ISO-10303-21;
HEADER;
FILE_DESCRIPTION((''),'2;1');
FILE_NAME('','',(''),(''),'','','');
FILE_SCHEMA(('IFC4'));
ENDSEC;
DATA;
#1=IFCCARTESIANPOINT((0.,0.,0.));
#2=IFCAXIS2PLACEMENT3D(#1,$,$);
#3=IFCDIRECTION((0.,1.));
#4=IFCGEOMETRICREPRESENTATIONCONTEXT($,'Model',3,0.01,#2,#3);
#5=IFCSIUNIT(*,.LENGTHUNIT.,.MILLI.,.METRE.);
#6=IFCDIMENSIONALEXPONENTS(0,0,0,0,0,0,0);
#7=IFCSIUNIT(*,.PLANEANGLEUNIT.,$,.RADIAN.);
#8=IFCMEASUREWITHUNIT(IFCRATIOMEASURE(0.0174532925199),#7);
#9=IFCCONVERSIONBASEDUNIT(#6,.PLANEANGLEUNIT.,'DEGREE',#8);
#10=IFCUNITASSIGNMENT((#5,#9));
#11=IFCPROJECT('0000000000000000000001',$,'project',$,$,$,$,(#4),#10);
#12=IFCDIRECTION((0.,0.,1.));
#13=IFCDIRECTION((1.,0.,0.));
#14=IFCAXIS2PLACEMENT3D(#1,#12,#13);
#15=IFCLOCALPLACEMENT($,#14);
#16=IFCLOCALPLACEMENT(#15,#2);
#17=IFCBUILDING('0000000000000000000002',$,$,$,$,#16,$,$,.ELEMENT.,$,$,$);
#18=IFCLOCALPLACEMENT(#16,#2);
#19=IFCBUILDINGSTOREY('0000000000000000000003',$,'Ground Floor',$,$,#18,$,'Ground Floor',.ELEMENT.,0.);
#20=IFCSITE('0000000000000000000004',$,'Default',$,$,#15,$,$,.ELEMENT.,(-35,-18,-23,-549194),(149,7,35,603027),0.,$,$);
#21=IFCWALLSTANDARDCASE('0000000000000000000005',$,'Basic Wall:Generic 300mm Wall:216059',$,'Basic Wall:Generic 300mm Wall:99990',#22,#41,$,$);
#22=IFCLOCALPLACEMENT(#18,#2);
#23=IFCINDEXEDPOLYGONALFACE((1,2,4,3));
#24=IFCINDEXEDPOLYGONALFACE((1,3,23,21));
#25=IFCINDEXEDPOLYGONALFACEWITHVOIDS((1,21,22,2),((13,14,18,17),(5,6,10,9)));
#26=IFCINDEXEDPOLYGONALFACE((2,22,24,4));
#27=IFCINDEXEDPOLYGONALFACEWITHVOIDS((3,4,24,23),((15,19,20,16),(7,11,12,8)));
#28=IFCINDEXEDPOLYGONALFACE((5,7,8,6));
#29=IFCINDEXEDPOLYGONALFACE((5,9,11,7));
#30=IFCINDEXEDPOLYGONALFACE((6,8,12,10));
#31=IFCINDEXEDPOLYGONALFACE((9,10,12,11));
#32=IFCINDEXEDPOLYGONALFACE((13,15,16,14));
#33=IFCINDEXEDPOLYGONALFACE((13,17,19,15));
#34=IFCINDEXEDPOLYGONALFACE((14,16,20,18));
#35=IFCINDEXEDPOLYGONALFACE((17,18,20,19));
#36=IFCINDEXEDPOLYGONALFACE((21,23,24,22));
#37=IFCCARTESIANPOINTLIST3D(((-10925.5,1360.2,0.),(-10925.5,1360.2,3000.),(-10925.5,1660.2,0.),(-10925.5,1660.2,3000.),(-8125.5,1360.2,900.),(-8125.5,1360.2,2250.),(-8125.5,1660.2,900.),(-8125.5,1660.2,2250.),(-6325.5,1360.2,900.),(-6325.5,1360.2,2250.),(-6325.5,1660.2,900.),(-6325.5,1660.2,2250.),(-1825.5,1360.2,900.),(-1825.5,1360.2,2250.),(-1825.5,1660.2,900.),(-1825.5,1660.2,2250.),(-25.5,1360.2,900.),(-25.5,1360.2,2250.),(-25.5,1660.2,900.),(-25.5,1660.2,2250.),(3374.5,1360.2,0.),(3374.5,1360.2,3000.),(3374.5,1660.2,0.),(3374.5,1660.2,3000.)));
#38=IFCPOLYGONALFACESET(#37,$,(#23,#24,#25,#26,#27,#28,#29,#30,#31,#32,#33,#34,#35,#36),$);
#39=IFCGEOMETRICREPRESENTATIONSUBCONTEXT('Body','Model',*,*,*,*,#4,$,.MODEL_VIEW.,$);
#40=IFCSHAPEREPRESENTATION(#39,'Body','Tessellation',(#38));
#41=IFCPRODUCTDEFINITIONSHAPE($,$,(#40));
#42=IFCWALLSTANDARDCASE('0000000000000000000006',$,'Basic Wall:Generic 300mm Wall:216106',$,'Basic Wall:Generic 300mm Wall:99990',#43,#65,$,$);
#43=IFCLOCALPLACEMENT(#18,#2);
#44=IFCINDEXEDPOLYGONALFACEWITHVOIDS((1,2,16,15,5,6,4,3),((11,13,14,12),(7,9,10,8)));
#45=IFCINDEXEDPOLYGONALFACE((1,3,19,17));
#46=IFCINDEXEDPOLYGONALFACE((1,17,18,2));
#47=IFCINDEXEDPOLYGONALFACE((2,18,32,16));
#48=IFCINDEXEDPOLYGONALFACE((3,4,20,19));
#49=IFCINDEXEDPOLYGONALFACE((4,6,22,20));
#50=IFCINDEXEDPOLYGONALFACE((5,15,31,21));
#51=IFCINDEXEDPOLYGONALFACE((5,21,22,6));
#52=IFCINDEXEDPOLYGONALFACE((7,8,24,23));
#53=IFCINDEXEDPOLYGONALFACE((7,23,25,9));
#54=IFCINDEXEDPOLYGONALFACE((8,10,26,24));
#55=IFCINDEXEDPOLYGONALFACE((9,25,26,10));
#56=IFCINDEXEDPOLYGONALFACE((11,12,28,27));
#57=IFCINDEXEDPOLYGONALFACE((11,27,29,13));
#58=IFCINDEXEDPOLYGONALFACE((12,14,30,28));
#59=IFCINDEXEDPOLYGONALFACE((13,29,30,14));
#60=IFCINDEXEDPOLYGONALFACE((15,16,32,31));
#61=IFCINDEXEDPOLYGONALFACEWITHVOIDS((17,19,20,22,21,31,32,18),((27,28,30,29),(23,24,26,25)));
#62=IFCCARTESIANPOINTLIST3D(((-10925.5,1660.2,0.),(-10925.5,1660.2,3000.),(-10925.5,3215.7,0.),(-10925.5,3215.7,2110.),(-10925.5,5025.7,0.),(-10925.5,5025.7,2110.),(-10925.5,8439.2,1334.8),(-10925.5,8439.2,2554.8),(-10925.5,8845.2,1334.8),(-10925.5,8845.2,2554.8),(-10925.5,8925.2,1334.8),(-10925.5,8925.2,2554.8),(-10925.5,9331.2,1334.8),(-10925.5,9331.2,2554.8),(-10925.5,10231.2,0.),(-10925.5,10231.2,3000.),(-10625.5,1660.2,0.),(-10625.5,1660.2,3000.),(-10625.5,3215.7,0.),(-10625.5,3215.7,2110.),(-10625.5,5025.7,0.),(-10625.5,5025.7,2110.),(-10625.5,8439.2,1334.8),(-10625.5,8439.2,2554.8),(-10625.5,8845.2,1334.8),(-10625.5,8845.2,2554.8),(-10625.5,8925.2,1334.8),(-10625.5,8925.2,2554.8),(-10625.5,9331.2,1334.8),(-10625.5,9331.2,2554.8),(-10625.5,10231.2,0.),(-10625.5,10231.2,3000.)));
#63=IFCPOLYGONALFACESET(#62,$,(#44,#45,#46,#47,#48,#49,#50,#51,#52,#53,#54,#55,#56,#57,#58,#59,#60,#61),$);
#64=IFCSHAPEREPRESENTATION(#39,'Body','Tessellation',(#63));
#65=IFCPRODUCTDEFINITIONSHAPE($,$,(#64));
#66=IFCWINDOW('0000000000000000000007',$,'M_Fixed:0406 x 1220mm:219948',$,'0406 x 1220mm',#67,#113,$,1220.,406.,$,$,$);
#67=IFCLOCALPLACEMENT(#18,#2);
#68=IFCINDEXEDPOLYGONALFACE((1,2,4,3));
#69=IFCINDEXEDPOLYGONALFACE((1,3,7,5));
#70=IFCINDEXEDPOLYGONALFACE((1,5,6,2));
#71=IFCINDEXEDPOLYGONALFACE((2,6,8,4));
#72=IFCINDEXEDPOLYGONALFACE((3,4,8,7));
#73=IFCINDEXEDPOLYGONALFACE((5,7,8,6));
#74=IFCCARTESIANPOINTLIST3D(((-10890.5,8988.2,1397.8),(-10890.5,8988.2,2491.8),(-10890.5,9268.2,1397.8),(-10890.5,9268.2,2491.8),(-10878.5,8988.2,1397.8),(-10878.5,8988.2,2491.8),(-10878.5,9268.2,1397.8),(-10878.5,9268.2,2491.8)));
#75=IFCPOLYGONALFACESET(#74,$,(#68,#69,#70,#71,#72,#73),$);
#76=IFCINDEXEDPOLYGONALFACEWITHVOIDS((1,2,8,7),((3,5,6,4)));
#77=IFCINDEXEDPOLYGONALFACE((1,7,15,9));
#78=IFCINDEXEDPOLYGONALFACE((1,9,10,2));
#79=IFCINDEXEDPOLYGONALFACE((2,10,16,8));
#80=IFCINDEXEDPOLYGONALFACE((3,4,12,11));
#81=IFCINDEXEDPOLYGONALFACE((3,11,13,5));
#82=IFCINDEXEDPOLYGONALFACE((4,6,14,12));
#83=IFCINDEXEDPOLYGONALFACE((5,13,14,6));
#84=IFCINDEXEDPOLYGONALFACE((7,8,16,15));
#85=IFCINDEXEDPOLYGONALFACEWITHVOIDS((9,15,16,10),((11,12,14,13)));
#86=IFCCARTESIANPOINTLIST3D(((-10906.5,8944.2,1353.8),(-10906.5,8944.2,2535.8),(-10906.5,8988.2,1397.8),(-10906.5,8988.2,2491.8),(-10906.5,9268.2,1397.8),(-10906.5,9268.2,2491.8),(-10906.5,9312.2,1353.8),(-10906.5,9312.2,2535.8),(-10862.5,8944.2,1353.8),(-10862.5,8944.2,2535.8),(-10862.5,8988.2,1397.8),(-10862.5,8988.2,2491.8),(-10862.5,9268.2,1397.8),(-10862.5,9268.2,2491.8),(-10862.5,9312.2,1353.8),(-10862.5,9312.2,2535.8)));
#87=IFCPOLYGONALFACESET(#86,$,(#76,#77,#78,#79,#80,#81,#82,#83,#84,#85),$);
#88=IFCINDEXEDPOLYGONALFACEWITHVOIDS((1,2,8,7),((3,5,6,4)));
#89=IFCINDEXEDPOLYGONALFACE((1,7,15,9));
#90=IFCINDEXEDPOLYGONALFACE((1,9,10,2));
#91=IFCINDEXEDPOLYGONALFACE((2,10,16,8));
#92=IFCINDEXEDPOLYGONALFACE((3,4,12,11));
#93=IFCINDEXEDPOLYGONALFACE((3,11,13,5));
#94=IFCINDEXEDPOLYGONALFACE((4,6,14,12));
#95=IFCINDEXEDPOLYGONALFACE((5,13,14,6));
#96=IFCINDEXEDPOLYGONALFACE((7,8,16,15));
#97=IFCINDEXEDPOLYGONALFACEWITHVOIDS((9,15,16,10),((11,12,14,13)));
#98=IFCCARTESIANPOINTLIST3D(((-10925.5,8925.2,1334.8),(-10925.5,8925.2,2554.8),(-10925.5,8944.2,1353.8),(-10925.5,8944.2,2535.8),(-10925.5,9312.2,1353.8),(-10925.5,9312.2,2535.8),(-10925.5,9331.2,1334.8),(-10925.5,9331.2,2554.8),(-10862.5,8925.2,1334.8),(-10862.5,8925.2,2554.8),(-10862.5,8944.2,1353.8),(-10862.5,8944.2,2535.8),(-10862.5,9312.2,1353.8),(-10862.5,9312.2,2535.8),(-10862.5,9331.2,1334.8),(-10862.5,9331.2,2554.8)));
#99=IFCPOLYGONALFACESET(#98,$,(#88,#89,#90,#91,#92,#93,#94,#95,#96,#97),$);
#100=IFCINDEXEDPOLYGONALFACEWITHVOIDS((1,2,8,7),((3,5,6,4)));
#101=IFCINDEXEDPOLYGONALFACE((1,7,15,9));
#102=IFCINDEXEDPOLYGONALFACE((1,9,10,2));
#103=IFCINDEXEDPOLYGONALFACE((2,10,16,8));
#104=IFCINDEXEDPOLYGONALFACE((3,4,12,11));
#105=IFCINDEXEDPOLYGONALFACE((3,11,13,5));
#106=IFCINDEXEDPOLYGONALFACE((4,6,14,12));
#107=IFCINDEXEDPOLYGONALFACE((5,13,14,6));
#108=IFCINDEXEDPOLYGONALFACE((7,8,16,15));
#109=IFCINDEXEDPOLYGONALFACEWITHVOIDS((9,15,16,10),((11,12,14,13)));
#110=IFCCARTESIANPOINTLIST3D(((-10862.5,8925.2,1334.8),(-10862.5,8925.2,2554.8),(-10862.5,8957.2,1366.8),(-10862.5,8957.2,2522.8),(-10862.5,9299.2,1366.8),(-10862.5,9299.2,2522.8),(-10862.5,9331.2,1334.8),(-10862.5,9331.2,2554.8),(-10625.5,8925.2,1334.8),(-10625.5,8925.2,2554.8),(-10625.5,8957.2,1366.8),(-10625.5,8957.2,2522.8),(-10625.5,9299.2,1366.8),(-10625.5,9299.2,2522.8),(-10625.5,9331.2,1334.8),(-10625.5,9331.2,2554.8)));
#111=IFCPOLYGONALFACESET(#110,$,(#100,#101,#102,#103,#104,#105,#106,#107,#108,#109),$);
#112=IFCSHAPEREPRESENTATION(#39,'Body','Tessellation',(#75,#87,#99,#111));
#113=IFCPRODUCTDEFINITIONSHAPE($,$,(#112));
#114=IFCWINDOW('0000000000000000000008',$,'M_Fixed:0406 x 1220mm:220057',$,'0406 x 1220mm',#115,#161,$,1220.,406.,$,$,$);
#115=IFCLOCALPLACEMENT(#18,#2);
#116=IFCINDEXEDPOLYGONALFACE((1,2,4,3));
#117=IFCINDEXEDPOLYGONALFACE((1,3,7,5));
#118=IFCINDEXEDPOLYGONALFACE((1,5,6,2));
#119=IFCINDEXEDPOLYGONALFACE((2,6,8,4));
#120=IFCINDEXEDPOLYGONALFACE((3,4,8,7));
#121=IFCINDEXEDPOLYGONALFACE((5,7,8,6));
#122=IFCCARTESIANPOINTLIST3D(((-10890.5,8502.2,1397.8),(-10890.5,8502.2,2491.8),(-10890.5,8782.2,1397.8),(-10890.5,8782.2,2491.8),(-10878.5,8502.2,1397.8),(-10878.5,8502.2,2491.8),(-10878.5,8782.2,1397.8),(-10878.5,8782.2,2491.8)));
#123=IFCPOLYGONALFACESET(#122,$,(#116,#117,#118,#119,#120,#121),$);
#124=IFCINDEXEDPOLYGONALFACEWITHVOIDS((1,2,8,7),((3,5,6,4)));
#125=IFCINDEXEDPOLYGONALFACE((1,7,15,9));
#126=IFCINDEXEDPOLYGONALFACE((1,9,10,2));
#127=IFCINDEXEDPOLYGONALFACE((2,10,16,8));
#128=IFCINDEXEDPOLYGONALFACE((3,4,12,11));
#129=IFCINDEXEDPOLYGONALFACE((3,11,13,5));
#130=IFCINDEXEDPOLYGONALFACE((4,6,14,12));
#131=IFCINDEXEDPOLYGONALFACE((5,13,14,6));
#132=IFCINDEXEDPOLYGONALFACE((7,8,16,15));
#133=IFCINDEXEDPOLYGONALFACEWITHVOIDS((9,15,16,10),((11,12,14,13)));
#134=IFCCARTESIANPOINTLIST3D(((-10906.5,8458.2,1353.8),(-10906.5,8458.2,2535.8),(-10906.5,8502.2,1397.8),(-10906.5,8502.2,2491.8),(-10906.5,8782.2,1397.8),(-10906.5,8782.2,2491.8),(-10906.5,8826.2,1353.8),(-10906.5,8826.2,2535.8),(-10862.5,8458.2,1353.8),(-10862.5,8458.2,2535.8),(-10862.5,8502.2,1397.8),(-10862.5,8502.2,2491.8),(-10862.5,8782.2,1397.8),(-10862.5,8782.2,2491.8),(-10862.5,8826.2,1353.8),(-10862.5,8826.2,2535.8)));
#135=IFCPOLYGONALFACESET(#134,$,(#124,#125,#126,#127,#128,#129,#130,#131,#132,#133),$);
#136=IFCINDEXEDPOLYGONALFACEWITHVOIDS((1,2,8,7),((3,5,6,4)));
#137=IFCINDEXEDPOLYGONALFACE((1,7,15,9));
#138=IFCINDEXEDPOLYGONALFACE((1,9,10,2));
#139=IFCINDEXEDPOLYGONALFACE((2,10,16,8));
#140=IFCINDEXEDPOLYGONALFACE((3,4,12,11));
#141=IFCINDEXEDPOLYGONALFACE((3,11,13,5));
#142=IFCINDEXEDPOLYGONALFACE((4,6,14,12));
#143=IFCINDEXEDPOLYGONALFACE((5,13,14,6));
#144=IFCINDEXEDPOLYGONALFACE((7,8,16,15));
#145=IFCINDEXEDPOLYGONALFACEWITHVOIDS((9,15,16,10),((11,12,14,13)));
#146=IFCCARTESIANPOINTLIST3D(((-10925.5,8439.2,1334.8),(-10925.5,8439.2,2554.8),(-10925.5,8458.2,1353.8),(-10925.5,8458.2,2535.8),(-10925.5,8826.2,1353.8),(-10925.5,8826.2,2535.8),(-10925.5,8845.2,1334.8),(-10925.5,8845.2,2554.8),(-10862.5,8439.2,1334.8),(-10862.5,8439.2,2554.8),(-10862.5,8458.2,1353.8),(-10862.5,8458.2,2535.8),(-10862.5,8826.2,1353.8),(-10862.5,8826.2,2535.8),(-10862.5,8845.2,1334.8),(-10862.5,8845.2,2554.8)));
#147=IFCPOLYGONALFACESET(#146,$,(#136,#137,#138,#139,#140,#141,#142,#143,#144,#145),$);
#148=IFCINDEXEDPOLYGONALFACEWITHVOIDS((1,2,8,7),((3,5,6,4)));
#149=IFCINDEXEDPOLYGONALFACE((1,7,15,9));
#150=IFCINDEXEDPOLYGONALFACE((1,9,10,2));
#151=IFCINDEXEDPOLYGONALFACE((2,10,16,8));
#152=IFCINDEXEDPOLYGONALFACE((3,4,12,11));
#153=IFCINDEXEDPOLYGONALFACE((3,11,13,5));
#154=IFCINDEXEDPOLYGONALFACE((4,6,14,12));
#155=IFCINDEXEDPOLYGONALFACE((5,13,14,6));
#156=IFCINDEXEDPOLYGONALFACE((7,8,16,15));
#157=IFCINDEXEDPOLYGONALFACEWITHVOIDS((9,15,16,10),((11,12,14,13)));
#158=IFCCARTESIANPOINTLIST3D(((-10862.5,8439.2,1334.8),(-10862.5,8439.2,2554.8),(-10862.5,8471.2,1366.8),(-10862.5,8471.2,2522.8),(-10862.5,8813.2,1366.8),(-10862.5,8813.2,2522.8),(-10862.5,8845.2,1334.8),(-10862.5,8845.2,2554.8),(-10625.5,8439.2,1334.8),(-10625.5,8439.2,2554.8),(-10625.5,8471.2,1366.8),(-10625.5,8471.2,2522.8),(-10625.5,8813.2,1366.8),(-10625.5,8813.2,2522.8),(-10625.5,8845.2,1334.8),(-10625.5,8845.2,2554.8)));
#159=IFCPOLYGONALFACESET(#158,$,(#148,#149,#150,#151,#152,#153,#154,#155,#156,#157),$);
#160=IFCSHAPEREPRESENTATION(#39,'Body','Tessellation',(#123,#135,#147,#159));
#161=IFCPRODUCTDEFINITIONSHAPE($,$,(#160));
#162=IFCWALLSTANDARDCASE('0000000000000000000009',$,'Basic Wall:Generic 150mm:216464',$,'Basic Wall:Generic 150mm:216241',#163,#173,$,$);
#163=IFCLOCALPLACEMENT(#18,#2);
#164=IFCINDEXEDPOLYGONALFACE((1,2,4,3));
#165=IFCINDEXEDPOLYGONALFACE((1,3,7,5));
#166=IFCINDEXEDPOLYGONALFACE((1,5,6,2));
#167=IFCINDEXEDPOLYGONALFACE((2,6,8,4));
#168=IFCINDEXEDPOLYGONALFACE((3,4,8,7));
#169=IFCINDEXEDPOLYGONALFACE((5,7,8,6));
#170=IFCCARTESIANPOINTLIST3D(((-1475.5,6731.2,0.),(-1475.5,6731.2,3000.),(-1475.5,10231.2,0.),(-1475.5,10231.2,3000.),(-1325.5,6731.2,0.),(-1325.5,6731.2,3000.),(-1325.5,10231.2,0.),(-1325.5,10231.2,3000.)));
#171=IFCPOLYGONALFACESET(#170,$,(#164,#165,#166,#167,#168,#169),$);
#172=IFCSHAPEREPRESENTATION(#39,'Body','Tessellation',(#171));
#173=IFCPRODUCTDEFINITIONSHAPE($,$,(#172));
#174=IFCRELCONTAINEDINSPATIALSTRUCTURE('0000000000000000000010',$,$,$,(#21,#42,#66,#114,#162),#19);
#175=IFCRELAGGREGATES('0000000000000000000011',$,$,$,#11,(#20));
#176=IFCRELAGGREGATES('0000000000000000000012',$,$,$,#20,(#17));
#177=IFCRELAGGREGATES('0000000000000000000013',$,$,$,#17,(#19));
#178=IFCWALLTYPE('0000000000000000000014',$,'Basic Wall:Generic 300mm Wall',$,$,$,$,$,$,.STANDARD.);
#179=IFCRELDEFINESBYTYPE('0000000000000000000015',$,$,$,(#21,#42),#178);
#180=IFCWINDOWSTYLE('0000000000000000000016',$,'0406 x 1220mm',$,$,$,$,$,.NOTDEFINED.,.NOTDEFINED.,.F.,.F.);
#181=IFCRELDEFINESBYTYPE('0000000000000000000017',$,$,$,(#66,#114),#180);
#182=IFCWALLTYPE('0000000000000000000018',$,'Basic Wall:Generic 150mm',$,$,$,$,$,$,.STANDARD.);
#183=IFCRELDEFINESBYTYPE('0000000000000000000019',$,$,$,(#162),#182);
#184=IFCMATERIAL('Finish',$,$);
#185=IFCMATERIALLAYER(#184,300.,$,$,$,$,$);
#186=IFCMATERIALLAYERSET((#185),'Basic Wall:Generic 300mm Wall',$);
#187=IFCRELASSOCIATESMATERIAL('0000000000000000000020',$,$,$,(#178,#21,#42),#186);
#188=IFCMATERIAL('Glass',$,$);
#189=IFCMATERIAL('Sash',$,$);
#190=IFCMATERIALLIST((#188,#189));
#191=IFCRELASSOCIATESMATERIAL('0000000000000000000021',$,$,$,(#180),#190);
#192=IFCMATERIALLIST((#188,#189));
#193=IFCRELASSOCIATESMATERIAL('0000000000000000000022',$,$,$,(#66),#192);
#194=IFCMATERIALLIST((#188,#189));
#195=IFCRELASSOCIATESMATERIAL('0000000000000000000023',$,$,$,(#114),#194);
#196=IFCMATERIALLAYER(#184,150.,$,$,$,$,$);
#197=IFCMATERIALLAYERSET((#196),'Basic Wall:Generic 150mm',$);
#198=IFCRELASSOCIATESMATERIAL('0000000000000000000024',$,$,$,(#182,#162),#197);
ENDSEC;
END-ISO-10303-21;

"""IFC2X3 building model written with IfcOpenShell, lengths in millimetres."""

from ifc_helpers import new_model, entity, si_unit, converted_unit, direction, frame, frame_2d, origin, origin_with_axes, place, context, subcontext, project, spatial, polyline, rectangle, outline, extrude, source, transform, mapped, material, material_list, layer, layer_set, layer_usage, type_object, type_shapes, element, fill, save


model = new_model("IFC2X3")

# Units and contexts
model_context = context("Model", 3, precision=0.01, world=origin(), true_north=direction((0.0, 1.0)))
body_context = subcontext(model_context, "Body", "Model", "MODEL_VIEW")
ifc_project = project(units=[si_unit("LENGTHUNIT", "METRE", prefix="MILLI"), converted_unit("PLANEANGLEUNIT", "DEGREE", entity("IfcRatioMeasure", 0.0174532925199), si_unit("PLANEANGLEUNIT", "RADIAN"), dimensions=[0, 0, 0, 0, 0, 0, 0])], contexts=[model_context])

# Site, building, storey
site_placement = place(None, origin_with_axes())
site = spatial("IfcSite", under=ifc_project, at=site_placement, Name="Default", CompositionType="ELEMENT", RefLatitude=(-35, -18, -23, -549194), RefLongitude=(149, 7, 35, 603027), RefElevation=0.0)
building_placement = place(site_placement, origin())
building = spatial("IfcBuilding", under=site, at=building_placement, CompositionType="ELEMENT")
storey_placement = place(building_placement, origin())
storey = spatial("IfcBuildingStorey", under=building, at=storey_placement, Name="Ground Floor", LongName="Ground Floor", CompositionType="ELEMENT", Elevation=0.0)

# Shared definitions
ifc_material_1 = material(Name="Finish")
ifc_layer_1 = layer(ifc_material_1, 300.0)
ifc_layer_set_1 = layer_set([ifc_layer_1], Name="Basic Wall:Generic 300mm Wall")
wall_type_1 = type_object("IfcWallType", Name="Basic Wall:Generic 300mm Wall", PredefinedType="STANDARD", material=ifc_layer_set_1)
ifc_material_2 = material(Name="Glass")
ifc_material_3 = material(Name="Sash")

# Wall, openings
ifc_layer_usage_1 = layer_usage(ifc_layer_set_1, "AXIS2", "NEGATIVE", 150.0)
wall_1_placement = place(storey_placement, frame((3374.5, 1510.2, 0.0), z_axis=(0.0, 0.0, 1.0), x_axis=(-1.0, 0.0, 0.0)))
wall_1 = element("IfcWallStandardCase", 1, at=wall_1_placement, inside=storey, type_object=wall_type_1, material=ifc_layer_usage_1, Name="Basic Wall:Generic 300mm Wall:216059", ObjectType="Basic Wall:Generic 300mm Wall:99990", context=body_context, shape_type="SweptSolid", body=[
    extrude(rectangle(XDim=14300.0, YDim=300.0, at=frame_2d((7150.0, 0.0), x_axis=(-1.0, 0.0))), origin(), (0.0, 0.0, 1.0), 3000.0),
])
opening_1_placement = place(wall_1_placement, frame((5200.0, 150.0, 900.0)))
element("IfcOpeningElement", 2, at=opening_1_placement, cuts=wall_1, ObjectType="Opening", context=body_context, shape_type="SweptSolid", body=[
    extrude(rectangle(XDim=1350.0, YDim=1800.0, at=frame_2d((675.0, 900.0), x_axis=(-1.0, 0.0))), frame((0.0, 0.0, 0.0), z_axis=(0.0, -1.0, 0.0), x_axis=(0.0, 0.0, 1.0)), (0.0, 0.0, 1.0), 300.0),
])
opening_2_placement = place(wall_1_placement, frame((11500.0, 150.0, 900.0)))
element("IfcOpeningElement", 3, at=opening_2_placement, cuts=wall_1, ObjectType="Opening", context=body_context, shape_type="SweptSolid", body=[
    extrude(rectangle(XDim=1350.0, YDim=1800.0, at=frame_2d((675.0, 900.0), x_axis=(-1.0, 0.0))), frame((0.0, 0.0, 0.0), z_axis=(0.0, -1.0, 0.0), x_axis=(0.0, 0.0, 1.0)), (0.0, 0.0, 1.0), 300.0),
])

# Wall, openings, windows
ifc_layer_usage_2 = layer_usage(ifc_layer_set_1, "AXIS2", "NEGATIVE", 150.0)
wall_2_placement = place(storey_placement, frame((-10775.5, 1660.2, 0.0), z_axis=(0.0, 0.0, 1.0), x_axis=(0.0, 1.0, 0.0)))
wall_2 = element("IfcWallStandardCase", 4, at=wall_2_placement, inside=storey, type_object=wall_type_1, material=ifc_layer_usage_2, Name="Basic Wall:Generic 300mm Wall:216106", ObjectType="Basic Wall:Generic 300mm Wall:99990", context=body_context, shape_type="SweptSolid", body=[
    extrude(rectangle(XDim=8571.0, YDim=300.0, at=frame_2d((4285.5, 0.0), x_axis=(-1.0, 0.0))), origin(), (0.0, 0.0, 1.0), 3000.0),
])
opening_3_placement = place(wall_2_placement, frame((1555.5, -150.0, 0.0)))
element("IfcOpeningElement", 5, at=opening_3_placement, cuts=wall_2, ObjectType="Opening", context=body_context, shape_type="SweptSolid", body=[
    extrude(rectangle(XDim=2110.0, YDim=1810.0, at=frame_2d((1055.0, 905.0), x_axis=(1.0, 0.0))), frame((0.0, 0.0, 0.0), z_axis=(0.0, 1.0, 0.0), x_axis=(0.0, 0.0, 1.0)), (0.0, 0.0, 1.0), 300.0),
])
opening_4_placement = place(wall_2_placement, frame((7265.0, -150.0, 1334.8)))
opening_4 = element("IfcOpeningElement", 6, at=opening_4_placement, cuts=wall_2, ObjectType="Opening", context=body_context, shape_type="SweptSolid", body=[
    extrude(rectangle(XDim=1220.0, YDim=406.0, at=frame_2d((610.0, 203.0), x_axis=(1.0, 0.0))), frame((0.0, 0.0, 0.0), z_axis=(0.0, 1.0, 0.0), x_axis=(0.0, 0.0, 1.0)), (0.0, 0.0, 1.0), 300.0),
])
opening_5_placement = place(wall_2_placement, frame((6779.0, -150.0, 1334.8)))
opening_5 = element("IfcOpeningElement", 7, at=opening_5_placement, cuts=wall_2, ObjectType="Opening", context=body_context, shape_type="SweptSolid", body=[
    extrude(rectangle(XDim=1220.0, YDim=406.0, at=frame_2d((610.0, 203.0), x_axis=(1.0, 0.0))), frame((0.0, 0.0, 0.0), z_axis=(0.0, 1.0, 0.0), x_axis=(0.0, 0.0, 1.0)), (0.0, 0.0, 1.0), 300.0),
])
ifc_material_list_1 = material_list([ifc_material_2, ifc_material_3])
ifc_material_list_2 = material_list([ifc_material_2, ifc_material_3])
window_style_1 = type_object("IfcWindowStyle", Name="0406 x 1220mm", ConstructionType="NOTDEFINED", OperationType="NOTDEFINED", ParameterTakesPrecedence=False, Sizeable=False, material=ifc_material_list_2)
shared_shape_1 = source(origin(), body_context, "Body", "SweptSolid", [
    extrude(rectangle(XDim=12.0, YDim=280.0, at=frame_2d((0.0, 0.0), x_axis=(1.0, 0.0))), frame((203.0, 259.0, 63.0), z_axis=(0.0, 0.0, 1.0), x_axis=(0.0, -1.0, 0.0)), (0.0, 0.0, 1.0), 1094.0),
    extrude(outline(polyline([(-184.0, -591.0), (184.0, -591.0), (184.0, 591.0), (-184.0, 591.0), (-184.0, -591.0)]), holes=[polyline([(-140.0, -547.0), (-140.0, 547.0), (140.0, 547.0), (140.0, -547.0), (-140.0, -547.0)])]), frame((203.0, 237.0, 610.0), z_axis=(0.0, 1.0, 0.0), x_axis=(1.0, 0.0, 0.0)), (0.0, 0.0, 1.0), 44.0),
    extrude(outline(polyline([(-203.0, -610.0), (203.0, -610.0), (203.0, 610.0), (-203.0, 610.0), (-203.0, -610.0)]), holes=[polyline([(-184.0, -591.0), (-184.0, 591.0), (184.0, 591.0), (184.0, -591.0), (-184.0, -591.0)])]), frame((203.0, 237.0, 610.0), z_axis=(0.0, 1.0, 0.0), x_axis=(1.0, 0.0, 0.0)), (0.0, 0.0, 1.0), 63.0),
    extrude(outline(polyline([(-203.0, -610.0), (203.0, -610.0), (203.0, 610.0), (-203.0, 610.0), (-203.0, -610.0)]), holes=[polyline([(-171.0, -578.0), (-171.0, 578.0), (171.0, 578.0), (171.0, -578.0), (-171.0, -578.0)])]), frame((203.0, 0.0, 610.0), z_axis=(0.0, 1.0, 0.0), x_axis=(1.0, 0.0, 0.0)), (0.0, 0.0, 1.0), 237.0),
])
type_shapes(window_style_1, [shared_shape_1])
window_1_placement = place(opening_4_placement, origin())
window_1 = element("IfcWindow", 8, at=window_1_placement, inside=storey, type_object=window_style_1, material=ifc_material_list_1, Name="M_Fixed:0406 x 1220mm:219948", ObjectType="0406 x 1220mm", OverallHeight=1220.0, OverallWidth=406.0, context=body_context, shape_type="MappedRepresentation", body=[
    mapped(shared_shape_1, transform((0.0, 0.0, 0.0), scale=1.0)),
])
fill(opening_4, window_1)
ifc_material_list_3 = material_list([ifc_material_2, ifc_material_3])
window_2_placement = place(opening_5_placement, origin())
window_2 = element("IfcWindow", 9, at=window_2_placement, inside=storey, type_object=window_style_1, material=ifc_material_list_3, Name="M_Fixed:0406 x 1220mm:220057", ObjectType="0406 x 1220mm", OverallHeight=1220.0, OverallWidth=406.0, context=body_context, shape_type="MappedRepresentation", body=[
    mapped(shared_shape_1, transform((0.0, 0.0, 0.0), scale=1.0)),
])
fill(opening_5, window_2)

# Wall
ifc_layer_2 = layer(ifc_material_1, 150.0)
ifc_layer_set_2 = layer_set([ifc_layer_2], Name="Basic Wall:Generic 150mm")
ifc_layer_usage_3 = layer_usage(ifc_layer_set_2, "AXIS2", "NEGATIVE", 75.0)
wall_type_2 = type_object("IfcWallType", Name="Basic Wall:Generic 150mm", PredefinedType="STANDARD", material=ifc_layer_set_2)
wall_3_placement = place(storey_placement, frame((-1400.5, 10231.2, 0.0), z_axis=(0.0, 0.0, 1.0), x_axis=(0.0, -1.0, 0.0)))
element("IfcWallStandardCase", 10, at=wall_3_placement, inside=storey, type_object=wall_type_2, material=ifc_layer_usage_3, Name="Basic Wall:Generic 150mm:216464", ObjectType="Basic Wall:Generic 150mm:216241", context=body_context, shape_type="SweptSolid", body=[
    extrude(rectangle(XDim=3500.0, YDim=150.0, at=frame_2d((1750.0, 0.0), x_axis=(-1.0, 0.0))), origin(), (0.0, 0.0, 1.0), 3000.0),
])

save(model, "model.ifc")
